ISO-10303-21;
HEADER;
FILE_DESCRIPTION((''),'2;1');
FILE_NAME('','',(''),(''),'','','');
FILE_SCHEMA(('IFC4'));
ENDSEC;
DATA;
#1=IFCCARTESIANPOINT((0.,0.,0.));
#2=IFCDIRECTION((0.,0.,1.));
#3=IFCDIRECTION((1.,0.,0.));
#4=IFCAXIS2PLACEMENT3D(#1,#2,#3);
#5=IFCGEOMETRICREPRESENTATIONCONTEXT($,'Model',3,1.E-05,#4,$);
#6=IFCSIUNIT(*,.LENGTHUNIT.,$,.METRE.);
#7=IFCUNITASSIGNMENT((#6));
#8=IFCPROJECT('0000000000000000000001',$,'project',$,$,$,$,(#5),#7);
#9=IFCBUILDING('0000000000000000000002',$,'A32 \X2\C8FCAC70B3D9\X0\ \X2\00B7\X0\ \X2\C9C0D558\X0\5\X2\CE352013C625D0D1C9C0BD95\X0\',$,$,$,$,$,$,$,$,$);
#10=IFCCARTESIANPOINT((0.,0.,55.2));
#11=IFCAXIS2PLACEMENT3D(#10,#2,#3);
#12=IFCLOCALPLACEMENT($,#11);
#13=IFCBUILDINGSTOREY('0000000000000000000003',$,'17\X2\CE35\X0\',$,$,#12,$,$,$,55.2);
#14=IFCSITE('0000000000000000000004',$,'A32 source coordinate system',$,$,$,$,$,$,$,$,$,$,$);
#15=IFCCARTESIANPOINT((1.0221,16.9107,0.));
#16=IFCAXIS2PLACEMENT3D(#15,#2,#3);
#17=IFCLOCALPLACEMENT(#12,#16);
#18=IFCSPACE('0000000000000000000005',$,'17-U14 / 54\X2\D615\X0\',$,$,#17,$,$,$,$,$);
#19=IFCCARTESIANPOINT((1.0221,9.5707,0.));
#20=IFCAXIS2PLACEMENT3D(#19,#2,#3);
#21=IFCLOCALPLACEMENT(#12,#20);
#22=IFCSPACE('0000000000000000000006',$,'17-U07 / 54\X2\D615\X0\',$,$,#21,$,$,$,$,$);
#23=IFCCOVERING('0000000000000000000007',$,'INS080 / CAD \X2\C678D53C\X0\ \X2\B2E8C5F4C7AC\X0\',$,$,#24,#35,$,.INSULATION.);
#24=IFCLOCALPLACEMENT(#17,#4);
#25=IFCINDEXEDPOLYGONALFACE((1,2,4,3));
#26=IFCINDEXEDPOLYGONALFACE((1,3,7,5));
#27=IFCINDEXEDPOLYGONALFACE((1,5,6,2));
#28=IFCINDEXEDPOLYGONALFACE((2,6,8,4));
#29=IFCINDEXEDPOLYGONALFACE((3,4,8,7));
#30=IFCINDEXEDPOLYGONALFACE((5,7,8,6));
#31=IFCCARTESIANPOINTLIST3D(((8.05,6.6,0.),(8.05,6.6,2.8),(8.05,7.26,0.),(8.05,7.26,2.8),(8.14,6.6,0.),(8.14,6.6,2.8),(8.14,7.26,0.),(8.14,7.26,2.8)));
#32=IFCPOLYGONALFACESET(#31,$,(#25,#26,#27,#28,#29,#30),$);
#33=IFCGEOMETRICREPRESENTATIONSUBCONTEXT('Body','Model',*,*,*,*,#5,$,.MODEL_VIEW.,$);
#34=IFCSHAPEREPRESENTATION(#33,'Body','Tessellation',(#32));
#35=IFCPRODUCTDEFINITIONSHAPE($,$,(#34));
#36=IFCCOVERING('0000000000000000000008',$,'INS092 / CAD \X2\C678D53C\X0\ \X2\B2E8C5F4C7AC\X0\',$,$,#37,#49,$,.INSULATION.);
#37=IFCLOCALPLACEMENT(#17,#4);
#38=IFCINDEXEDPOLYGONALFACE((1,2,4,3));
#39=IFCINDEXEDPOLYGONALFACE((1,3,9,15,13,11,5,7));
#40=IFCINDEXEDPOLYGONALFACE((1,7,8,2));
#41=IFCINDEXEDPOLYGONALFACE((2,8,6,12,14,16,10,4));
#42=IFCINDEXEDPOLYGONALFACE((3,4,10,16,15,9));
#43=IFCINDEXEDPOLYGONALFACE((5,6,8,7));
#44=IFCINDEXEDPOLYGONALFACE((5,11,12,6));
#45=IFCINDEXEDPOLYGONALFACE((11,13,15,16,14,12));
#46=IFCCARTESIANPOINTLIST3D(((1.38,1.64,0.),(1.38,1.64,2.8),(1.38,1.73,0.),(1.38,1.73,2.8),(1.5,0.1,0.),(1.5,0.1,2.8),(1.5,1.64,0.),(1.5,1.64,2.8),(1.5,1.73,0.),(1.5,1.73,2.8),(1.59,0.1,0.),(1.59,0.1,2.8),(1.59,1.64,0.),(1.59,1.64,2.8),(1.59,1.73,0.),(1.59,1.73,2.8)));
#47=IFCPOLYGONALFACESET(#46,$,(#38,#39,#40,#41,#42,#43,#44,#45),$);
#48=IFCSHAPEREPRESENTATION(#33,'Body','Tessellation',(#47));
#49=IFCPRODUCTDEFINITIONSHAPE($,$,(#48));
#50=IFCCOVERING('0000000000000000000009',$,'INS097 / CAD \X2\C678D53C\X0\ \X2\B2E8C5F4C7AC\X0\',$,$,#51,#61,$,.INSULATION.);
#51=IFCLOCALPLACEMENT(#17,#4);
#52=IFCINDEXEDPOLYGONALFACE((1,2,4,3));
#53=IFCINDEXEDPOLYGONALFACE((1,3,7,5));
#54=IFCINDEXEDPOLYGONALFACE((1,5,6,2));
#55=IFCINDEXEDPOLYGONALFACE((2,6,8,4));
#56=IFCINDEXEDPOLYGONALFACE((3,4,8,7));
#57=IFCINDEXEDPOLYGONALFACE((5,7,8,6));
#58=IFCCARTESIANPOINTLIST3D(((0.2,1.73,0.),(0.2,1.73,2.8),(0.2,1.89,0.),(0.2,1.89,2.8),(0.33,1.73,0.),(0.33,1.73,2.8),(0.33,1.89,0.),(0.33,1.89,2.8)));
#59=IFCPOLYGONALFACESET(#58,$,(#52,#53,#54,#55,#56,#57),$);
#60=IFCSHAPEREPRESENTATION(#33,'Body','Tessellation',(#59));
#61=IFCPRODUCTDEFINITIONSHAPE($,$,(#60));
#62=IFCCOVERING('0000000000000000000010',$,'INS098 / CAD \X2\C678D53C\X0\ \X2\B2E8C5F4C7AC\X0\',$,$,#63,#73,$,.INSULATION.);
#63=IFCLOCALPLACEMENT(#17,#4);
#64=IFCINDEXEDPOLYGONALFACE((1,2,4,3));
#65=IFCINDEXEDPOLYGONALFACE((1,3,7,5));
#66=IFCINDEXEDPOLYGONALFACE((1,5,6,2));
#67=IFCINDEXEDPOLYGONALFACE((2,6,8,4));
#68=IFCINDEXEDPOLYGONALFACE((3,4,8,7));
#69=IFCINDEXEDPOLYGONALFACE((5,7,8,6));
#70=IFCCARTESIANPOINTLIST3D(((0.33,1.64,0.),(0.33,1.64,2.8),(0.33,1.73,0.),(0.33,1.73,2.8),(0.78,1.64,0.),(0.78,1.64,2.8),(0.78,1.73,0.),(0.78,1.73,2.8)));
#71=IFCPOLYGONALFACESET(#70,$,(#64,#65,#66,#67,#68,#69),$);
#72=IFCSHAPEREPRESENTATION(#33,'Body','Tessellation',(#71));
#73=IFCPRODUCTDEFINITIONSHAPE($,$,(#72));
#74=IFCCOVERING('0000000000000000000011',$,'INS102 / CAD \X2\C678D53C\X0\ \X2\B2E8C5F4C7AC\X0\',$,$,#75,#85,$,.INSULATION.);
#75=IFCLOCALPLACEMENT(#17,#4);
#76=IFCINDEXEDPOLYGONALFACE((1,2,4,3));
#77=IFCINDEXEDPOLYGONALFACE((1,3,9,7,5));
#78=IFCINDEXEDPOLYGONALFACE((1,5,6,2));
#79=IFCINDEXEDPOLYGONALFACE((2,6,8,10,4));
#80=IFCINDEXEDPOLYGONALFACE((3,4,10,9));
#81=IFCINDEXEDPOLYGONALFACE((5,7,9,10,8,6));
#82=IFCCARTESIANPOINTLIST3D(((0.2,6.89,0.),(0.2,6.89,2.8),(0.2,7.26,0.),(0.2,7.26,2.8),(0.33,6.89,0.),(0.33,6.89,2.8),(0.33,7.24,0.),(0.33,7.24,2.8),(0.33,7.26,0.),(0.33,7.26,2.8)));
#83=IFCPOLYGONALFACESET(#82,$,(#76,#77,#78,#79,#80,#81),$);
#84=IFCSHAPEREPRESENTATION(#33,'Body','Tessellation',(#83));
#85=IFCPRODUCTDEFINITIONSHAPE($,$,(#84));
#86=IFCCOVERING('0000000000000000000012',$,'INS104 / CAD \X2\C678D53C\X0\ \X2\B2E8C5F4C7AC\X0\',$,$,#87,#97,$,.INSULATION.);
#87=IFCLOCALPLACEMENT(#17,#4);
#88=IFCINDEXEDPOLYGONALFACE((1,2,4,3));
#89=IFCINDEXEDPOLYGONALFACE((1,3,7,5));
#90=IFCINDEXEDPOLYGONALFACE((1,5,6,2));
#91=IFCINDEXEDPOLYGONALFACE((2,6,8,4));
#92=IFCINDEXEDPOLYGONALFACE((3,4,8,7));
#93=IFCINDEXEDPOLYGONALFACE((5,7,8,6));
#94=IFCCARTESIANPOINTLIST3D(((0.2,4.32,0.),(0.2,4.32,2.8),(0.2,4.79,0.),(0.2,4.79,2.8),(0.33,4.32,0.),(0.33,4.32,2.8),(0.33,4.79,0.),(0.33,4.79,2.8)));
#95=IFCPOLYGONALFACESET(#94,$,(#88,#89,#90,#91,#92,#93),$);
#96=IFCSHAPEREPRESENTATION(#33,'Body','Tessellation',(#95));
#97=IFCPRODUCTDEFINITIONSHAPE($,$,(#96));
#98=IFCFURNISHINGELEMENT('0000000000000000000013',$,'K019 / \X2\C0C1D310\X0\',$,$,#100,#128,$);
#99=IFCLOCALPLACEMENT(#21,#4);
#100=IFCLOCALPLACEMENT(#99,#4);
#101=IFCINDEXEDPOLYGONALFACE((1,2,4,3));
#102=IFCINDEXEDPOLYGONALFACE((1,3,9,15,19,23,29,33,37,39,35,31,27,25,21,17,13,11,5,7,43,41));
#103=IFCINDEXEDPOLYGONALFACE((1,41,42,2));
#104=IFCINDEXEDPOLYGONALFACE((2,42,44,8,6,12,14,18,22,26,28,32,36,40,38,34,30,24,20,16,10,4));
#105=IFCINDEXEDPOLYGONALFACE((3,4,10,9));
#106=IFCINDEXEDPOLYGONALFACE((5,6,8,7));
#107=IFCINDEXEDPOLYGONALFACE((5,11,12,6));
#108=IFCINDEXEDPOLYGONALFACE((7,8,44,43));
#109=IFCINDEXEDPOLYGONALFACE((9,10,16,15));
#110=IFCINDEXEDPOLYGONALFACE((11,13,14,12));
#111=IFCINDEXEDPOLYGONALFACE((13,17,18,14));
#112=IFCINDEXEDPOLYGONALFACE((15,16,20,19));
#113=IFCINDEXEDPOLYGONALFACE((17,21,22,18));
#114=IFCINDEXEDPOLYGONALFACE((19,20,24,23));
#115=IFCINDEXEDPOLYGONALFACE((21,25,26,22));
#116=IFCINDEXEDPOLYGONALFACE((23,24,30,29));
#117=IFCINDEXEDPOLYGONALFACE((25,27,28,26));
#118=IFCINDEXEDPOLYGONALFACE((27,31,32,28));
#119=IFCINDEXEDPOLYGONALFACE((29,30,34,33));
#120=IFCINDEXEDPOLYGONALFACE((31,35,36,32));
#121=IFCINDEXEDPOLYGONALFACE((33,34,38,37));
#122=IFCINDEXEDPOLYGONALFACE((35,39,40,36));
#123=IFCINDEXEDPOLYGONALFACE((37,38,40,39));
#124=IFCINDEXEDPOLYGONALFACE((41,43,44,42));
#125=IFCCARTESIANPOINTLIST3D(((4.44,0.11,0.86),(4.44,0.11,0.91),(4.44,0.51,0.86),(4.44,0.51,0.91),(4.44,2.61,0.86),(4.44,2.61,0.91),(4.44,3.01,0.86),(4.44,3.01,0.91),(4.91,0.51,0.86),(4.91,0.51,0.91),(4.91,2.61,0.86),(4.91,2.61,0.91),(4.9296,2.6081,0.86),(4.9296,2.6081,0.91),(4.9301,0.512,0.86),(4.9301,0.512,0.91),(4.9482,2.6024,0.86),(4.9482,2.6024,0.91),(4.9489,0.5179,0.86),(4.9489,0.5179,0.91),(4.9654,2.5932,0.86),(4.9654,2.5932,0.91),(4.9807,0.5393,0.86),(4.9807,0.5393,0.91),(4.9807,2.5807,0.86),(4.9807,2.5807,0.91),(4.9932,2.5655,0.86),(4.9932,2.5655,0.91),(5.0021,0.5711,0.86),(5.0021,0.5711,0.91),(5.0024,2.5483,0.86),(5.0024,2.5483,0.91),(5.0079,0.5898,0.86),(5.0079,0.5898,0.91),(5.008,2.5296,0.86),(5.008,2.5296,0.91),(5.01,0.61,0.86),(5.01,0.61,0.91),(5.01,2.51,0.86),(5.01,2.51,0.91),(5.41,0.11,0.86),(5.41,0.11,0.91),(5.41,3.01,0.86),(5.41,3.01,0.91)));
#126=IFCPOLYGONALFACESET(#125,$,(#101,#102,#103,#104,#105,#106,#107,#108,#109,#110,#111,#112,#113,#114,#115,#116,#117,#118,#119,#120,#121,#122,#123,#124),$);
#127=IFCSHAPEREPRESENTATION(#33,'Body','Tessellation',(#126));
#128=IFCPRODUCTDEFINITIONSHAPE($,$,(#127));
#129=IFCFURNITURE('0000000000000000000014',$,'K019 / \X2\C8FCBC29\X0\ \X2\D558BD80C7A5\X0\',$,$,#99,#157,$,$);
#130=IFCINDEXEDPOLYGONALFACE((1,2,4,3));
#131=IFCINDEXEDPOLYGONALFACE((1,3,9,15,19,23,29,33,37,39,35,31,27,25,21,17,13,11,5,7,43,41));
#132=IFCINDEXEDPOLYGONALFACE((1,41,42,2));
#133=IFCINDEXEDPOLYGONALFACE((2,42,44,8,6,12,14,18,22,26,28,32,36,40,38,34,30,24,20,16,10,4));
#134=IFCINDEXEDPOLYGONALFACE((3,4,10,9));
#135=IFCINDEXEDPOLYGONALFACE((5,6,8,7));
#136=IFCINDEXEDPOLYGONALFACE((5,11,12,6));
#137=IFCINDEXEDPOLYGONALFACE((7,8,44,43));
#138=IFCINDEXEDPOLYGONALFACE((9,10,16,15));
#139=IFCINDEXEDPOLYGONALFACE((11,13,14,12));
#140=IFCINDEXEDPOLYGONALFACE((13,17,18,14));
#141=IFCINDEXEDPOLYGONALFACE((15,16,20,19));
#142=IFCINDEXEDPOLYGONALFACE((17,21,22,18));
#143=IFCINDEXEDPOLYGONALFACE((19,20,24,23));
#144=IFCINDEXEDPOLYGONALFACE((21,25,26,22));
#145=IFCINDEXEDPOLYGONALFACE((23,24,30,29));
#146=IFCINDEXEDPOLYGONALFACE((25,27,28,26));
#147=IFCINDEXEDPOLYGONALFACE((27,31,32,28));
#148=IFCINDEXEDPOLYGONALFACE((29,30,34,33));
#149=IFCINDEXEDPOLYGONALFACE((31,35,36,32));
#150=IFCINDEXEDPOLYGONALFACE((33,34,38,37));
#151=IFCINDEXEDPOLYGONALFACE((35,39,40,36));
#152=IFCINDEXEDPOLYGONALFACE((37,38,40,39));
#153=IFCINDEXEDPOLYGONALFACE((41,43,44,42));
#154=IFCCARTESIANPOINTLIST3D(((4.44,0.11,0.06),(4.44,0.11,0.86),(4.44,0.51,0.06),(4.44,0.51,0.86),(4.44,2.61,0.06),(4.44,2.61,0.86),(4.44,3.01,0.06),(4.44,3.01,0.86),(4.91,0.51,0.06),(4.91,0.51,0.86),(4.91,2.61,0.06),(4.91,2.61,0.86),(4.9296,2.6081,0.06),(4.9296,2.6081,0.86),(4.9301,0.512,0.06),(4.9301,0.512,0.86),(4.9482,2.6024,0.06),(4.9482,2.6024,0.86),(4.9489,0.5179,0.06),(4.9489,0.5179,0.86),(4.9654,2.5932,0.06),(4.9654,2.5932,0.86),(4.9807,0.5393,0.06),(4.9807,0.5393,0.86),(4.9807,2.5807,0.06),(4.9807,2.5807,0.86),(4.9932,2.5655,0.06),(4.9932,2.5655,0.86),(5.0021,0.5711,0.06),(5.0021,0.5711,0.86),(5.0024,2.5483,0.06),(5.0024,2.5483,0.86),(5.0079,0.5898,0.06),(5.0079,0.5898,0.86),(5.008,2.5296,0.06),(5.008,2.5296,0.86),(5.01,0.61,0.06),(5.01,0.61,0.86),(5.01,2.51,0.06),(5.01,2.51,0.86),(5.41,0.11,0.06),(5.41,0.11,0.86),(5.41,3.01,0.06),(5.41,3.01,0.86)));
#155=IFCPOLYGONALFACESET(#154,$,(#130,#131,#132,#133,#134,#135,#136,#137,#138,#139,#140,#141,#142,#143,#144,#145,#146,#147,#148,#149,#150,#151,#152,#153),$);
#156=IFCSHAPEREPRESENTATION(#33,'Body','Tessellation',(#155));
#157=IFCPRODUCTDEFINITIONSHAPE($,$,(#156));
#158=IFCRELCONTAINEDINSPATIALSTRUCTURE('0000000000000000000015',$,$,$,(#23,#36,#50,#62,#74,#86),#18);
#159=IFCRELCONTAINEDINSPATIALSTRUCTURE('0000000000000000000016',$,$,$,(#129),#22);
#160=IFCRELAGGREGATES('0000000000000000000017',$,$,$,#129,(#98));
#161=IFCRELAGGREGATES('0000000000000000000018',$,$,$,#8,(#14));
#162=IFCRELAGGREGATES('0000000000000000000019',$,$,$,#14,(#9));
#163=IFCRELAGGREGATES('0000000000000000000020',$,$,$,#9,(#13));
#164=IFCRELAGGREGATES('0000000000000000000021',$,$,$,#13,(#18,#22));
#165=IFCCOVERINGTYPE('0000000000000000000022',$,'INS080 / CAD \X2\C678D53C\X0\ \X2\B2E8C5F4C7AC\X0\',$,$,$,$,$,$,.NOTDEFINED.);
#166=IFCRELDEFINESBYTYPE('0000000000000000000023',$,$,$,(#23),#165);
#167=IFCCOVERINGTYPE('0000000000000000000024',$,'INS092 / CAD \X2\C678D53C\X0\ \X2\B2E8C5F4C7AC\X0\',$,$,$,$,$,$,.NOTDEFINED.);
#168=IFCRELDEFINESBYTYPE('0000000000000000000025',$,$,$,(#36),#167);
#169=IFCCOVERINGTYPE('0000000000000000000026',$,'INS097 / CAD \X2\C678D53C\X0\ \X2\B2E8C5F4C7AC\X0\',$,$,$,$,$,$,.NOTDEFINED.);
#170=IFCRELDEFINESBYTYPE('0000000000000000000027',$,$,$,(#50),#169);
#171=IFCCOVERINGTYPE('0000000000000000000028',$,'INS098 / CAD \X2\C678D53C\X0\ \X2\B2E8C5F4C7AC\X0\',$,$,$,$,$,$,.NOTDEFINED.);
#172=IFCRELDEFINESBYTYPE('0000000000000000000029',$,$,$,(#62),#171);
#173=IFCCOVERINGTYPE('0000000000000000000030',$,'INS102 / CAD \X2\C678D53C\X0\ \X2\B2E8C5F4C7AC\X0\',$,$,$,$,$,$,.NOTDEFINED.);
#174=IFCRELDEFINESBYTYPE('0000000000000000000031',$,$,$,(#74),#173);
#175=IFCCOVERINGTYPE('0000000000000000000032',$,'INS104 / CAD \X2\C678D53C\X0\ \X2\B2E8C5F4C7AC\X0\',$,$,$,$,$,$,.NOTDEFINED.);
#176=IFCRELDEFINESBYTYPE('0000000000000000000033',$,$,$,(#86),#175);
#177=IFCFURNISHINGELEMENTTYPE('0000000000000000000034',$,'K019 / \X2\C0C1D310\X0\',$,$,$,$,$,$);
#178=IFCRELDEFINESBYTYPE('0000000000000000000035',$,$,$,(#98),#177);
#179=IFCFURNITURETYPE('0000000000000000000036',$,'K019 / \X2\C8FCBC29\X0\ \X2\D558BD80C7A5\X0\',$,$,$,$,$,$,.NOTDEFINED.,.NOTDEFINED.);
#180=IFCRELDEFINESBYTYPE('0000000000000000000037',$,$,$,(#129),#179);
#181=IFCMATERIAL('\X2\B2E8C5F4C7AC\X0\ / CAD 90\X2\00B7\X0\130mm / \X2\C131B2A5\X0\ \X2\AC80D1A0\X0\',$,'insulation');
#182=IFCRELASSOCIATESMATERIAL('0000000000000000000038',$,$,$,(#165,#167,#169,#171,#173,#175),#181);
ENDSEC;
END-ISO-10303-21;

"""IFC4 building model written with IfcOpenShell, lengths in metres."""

from ifc_helpers import new_model, si_unit, frame, origin, origin_with_axes, place, context, subcontext, project, spatial, polyline, outline, extrude, source, transform, mapped, material, type_object, type_shapes, element, aggregate, save


model = new_model("IFC4")

# Units and contexts
model_context = context("Model", 3, precision=1e-05, world=origin_with_axes())
body_context = subcontext(model_context, "Body", "Model", "MODEL_VIEW")
ifc_project = project(units=[si_unit("LENGTHUNIT", "METRE")], contexts=[model_context])

# Site, building, storey, space
storey_placement = place(None, frame((0.0, 0.0, 55.2), z_axis=(0.0, 0.0, 1.0), x_axis=(1.0, 0.0, 0.0)))
space_1_placement = place(storey_placement, frame((1.0221, 16.9107, 0.0), z_axis=(0.0, 0.0, 1.0), x_axis=(1.0, 0.0, 0.0)))
site = spatial("IfcSite", under=ifc_project, Name="A32 source coordinate system")
building = spatial("IfcBuilding", under=site, Name="A32 주거동 · 지하5층–옥탑지붕")
storey = spatial("IfcBuildingStorey", under=building, at=storey_placement, Name="17층", Elevation=55.2)
space_1 = spatial("IfcSpace", under=storey, at=space_1_placement, Name="17-U14 / 54형")

# Coverings
ifc_material = material(Name="단열재 / CAD 90·130mm / 성능 검토", Category="insulation")
covering_type_1 = type_object("IfcCoveringType", Name="INS080 / CAD 외피 단열재", PredefinedType="NOTDEFINED", material=ifc_material)
shared_shape_1 = source(origin(), body_context, "Body", "SweptSolid", [
    extrude(outline(polyline([(8.14, 7.26), (8.14, 6.6), (8.05, 6.6), (8.05, 7.26), (8.14, 7.26)])), origin(), (0.0, 0.0, 1.0), 2.8),
])
type_shapes(covering_type_1, [shared_shape_1])
covering_1_placement = place(space_1_placement, origin_with_axes())
element("IfcCovering", 1, at=covering_1_placement, inside=space_1, type_object=covering_type_1, Name="INS080 / CAD 외피 단열재", PredefinedType="INSULATION", context=body_context, shape_type="MappedRepresentation", body=[
    mapped(shared_shape_1, transform((0.0, 0.0, 0.0), scale=1.0)),
])
covering_type_2 = type_object("IfcCoveringType", Name="INS092 / CAD 외피 단열재", PredefinedType="NOTDEFINED", material=ifc_material)
shared_shape_2 = source(origin(), body_context, "Body", "SweptSolid", [
    extrude(outline(polyline([(1.59, 1.73), (1.59, 1.64), (1.59, 0.1), (1.5, 0.1), (1.5, 1.64), (1.38, 1.64), (1.38, 1.73), (1.5, 1.73), (1.59, 1.73)])), origin(), (0.0, 0.0, 1.0), 2.8),
])
type_shapes(covering_type_2, [shared_shape_2])
covering_2_placement = place(space_1_placement, origin_with_axes())
element("IfcCovering", 2, at=covering_2_placement, inside=space_1, type_object=covering_type_2, Name="INS092 / CAD 외피 단열재", PredefinedType="INSULATION", context=body_context, shape_type="MappedRepresentation", body=[
    mapped(shared_shape_2, transform((0.0, 0.0, 0.0), scale=1.0)),
])
covering_type_3 = type_object("IfcCoveringType", Name="INS097 / CAD 외피 단열재", PredefinedType="NOTDEFINED", material=ifc_material)
shared_shape_3 = source(origin(), body_context, "Body", "SweptSolid", [
    extrude(outline(polyline([(0.33, 1.89), (0.33, 1.73), (0.2, 1.73), (0.2, 1.89), (0.33, 1.89)])), origin(), (0.0, 0.0, 1.0), 2.8),
])
type_shapes(covering_type_3, [shared_shape_3])
covering_3_placement = place(space_1_placement, origin_with_axes())
element("IfcCovering", 3, at=covering_3_placement, inside=space_1, type_object=covering_type_3, Name="INS097 / CAD 외피 단열재", PredefinedType="INSULATION", context=body_context, shape_type="MappedRepresentation", body=[
    mapped(shared_shape_3, transform((0.0, 0.0, 0.0), scale=1.0)),
])
covering_type_4 = type_object("IfcCoveringType", Name="INS098 / CAD 외피 단열재", PredefinedType="NOTDEFINED", material=ifc_material)
shared_shape_4 = source(origin(), body_context, "Body", "SweptSolid", [
    extrude(outline(polyline([(0.78, 1.73), (0.78, 1.64), (0.33, 1.64), (0.33, 1.73), (0.78, 1.73)])), origin(), (0.0, 0.0, 1.0), 2.8),
])
type_shapes(covering_type_4, [shared_shape_4])
covering_4_placement = place(space_1_placement, origin_with_axes())
element("IfcCovering", 4, at=covering_4_placement, inside=space_1, type_object=covering_type_4, Name="INS098 / CAD 외피 단열재", PredefinedType="INSULATION", context=body_context, shape_type="MappedRepresentation", body=[
    mapped(shared_shape_4, transform((0.0, 0.0, 0.0), scale=1.0)),
])
covering_type_5 = type_object("IfcCoveringType", Name="INS102 / CAD 외피 단열재", PredefinedType="NOTDEFINED", material=ifc_material)
shared_shape_5 = source(origin(), body_context, "Body", "SweptSolid", [
    extrude(outline(polyline([(0.33, 7.26), (0.33, 7.24), (0.33, 6.89), (0.2, 6.89), (0.2, 7.26), (0.33, 7.26)])), origin(), (0.0, 0.0, 1.0), 2.8),
])
type_shapes(covering_type_5, [shared_shape_5])
covering_5_placement = place(space_1_placement, origin_with_axes())
element("IfcCovering", 5, at=covering_5_placement, inside=space_1, type_object=covering_type_5, Name="INS102 / CAD 외피 단열재", PredefinedType="INSULATION", context=body_context, shape_type="MappedRepresentation", body=[
    mapped(shared_shape_5, transform((0.0, 0.0, 0.0), scale=1.0)),
])
covering_type_6 = type_object("IfcCoveringType", Name="INS104 / CAD 외피 단열재", PredefinedType="NOTDEFINED", material=ifc_material)
shared_shape_6 = source(origin(), body_context, "Body", "SweptSolid", [
    extrude(outline(polyline([(0.33, 4.32), (0.2, 4.32), (0.2, 4.79), (0.33, 4.79), (0.33, 4.32)])), origin(), (0.0, 0.0, 1.0), 2.8),
])
type_shapes(covering_type_6, [shared_shape_6])
covering_6_placement = place(space_1_placement, origin_with_axes())
element("IfcCovering", 6, at=covering_6_placement, inside=space_1, type_object=covering_type_6, Name="INS104 / CAD 외피 단열재", PredefinedType="INSULATION", context=body_context, shape_type="MappedRepresentation", body=[
    mapped(shared_shape_6, transform((0.0, 0.0, 0.0), scale=1.0)),
])

# Furnishing element
furnishing_element_type = type_object("IfcFurnishingElementType", Name="K019 / 상판")
shared_shape_7 = source(origin(), body_context, "Body", "SweptSolid", [
    extrude(outline(polyline([(4.91, 0.51), (4.9301, 0.512), (4.9489, 0.5179), (4.9807, 0.5393), (5.0021, 0.5711), (5.0079, 0.5898), (5.01, 0.61), (5.01, 2.51), (5.008, 2.5296), (5.0024, 2.5483), (4.9932, 2.5655), (4.9807, 2.5807), (4.9654, 2.5932), (4.9482, 2.6024), (4.9296, 2.6081), (4.91, 2.61), (4.44, 2.61), (4.44, 3.01), (5.41, 3.01), (5.41, 0.11), (4.44, 0.11), (4.44, 0.51), (4.91, 0.51)])), frame((0.0, 0.0, 0.86)), (0.0, 0.0, 1.0), 0.05),
])
type_shapes(furnishing_element_type, [shared_shape_7])
space_2_placement = place(storey_placement, frame((1.0221, 9.5707, 0.0), z_axis=(0.0, 0.0, 1.0), x_axis=(1.0, 0.0, 0.0)))
furniture_placement = place(space_2_placement, origin_with_axes())
furnishing_placement = place(furniture_placement, origin_with_axes())
furnishing = element("IfcFurnishingElement", 7, at=furnishing_placement, type_object=furnishing_element_type, Name="K019 / 상판", context=body_context, shape_type="MappedRepresentation", body=[
    mapped(shared_shape_7, transform((0.0, 0.0, 0.0), scale=1.0)),
])

# Shared definitions
space_2 = spatial("IfcSpace", under=storey, at=space_2_placement, Name="17-U07 / 54형")

# Furniture
furniture_type = type_object("IfcFurnitureType", Name="K019 / 주방 하부장", AssemblyPlace="NOTDEFINED", PredefinedType="NOTDEFINED")
shared_shape_8 = source(origin(), body_context, "Body", "SweptSolid", [
    extrude(outline(polyline([(4.44, 0.51), (4.91, 0.51), (4.9301, 0.512), (4.9489, 0.5179), (4.9807, 0.5393), (5.0021, 0.5711), (5.0079, 0.5898), (5.01, 0.61), (5.01, 2.51), (5.008, 2.5296), (5.0024, 2.5483), (4.9932, 2.5655), (4.9807, 2.5807), (4.9654, 2.5932), (4.9482, 2.6024), (4.9296, 2.6081), (4.91, 2.61), (4.44, 2.61), (4.44, 3.01), (5.41, 3.01), (5.41, 0.11), (4.44, 0.11), (4.44, 0.51)])), frame((0.0, 0.0, 0.06)), (0.0, 0.0, 1.0), 0.8),
])
type_shapes(furniture_type, [shared_shape_8])
furniture = element("IfcFurniture", 8, at=furniture_placement, inside=space_2, type_object=furniture_type, Name="K019 / 주방 하부장", context=body_context, shape_type="MappedRepresentation", body=[
    mapped(shared_shape_8, transform((0.0, 0.0, 0.0), scale=1.0)),
])
aggregate(furniture, [furnishing])

save(model, "model.ifc")
